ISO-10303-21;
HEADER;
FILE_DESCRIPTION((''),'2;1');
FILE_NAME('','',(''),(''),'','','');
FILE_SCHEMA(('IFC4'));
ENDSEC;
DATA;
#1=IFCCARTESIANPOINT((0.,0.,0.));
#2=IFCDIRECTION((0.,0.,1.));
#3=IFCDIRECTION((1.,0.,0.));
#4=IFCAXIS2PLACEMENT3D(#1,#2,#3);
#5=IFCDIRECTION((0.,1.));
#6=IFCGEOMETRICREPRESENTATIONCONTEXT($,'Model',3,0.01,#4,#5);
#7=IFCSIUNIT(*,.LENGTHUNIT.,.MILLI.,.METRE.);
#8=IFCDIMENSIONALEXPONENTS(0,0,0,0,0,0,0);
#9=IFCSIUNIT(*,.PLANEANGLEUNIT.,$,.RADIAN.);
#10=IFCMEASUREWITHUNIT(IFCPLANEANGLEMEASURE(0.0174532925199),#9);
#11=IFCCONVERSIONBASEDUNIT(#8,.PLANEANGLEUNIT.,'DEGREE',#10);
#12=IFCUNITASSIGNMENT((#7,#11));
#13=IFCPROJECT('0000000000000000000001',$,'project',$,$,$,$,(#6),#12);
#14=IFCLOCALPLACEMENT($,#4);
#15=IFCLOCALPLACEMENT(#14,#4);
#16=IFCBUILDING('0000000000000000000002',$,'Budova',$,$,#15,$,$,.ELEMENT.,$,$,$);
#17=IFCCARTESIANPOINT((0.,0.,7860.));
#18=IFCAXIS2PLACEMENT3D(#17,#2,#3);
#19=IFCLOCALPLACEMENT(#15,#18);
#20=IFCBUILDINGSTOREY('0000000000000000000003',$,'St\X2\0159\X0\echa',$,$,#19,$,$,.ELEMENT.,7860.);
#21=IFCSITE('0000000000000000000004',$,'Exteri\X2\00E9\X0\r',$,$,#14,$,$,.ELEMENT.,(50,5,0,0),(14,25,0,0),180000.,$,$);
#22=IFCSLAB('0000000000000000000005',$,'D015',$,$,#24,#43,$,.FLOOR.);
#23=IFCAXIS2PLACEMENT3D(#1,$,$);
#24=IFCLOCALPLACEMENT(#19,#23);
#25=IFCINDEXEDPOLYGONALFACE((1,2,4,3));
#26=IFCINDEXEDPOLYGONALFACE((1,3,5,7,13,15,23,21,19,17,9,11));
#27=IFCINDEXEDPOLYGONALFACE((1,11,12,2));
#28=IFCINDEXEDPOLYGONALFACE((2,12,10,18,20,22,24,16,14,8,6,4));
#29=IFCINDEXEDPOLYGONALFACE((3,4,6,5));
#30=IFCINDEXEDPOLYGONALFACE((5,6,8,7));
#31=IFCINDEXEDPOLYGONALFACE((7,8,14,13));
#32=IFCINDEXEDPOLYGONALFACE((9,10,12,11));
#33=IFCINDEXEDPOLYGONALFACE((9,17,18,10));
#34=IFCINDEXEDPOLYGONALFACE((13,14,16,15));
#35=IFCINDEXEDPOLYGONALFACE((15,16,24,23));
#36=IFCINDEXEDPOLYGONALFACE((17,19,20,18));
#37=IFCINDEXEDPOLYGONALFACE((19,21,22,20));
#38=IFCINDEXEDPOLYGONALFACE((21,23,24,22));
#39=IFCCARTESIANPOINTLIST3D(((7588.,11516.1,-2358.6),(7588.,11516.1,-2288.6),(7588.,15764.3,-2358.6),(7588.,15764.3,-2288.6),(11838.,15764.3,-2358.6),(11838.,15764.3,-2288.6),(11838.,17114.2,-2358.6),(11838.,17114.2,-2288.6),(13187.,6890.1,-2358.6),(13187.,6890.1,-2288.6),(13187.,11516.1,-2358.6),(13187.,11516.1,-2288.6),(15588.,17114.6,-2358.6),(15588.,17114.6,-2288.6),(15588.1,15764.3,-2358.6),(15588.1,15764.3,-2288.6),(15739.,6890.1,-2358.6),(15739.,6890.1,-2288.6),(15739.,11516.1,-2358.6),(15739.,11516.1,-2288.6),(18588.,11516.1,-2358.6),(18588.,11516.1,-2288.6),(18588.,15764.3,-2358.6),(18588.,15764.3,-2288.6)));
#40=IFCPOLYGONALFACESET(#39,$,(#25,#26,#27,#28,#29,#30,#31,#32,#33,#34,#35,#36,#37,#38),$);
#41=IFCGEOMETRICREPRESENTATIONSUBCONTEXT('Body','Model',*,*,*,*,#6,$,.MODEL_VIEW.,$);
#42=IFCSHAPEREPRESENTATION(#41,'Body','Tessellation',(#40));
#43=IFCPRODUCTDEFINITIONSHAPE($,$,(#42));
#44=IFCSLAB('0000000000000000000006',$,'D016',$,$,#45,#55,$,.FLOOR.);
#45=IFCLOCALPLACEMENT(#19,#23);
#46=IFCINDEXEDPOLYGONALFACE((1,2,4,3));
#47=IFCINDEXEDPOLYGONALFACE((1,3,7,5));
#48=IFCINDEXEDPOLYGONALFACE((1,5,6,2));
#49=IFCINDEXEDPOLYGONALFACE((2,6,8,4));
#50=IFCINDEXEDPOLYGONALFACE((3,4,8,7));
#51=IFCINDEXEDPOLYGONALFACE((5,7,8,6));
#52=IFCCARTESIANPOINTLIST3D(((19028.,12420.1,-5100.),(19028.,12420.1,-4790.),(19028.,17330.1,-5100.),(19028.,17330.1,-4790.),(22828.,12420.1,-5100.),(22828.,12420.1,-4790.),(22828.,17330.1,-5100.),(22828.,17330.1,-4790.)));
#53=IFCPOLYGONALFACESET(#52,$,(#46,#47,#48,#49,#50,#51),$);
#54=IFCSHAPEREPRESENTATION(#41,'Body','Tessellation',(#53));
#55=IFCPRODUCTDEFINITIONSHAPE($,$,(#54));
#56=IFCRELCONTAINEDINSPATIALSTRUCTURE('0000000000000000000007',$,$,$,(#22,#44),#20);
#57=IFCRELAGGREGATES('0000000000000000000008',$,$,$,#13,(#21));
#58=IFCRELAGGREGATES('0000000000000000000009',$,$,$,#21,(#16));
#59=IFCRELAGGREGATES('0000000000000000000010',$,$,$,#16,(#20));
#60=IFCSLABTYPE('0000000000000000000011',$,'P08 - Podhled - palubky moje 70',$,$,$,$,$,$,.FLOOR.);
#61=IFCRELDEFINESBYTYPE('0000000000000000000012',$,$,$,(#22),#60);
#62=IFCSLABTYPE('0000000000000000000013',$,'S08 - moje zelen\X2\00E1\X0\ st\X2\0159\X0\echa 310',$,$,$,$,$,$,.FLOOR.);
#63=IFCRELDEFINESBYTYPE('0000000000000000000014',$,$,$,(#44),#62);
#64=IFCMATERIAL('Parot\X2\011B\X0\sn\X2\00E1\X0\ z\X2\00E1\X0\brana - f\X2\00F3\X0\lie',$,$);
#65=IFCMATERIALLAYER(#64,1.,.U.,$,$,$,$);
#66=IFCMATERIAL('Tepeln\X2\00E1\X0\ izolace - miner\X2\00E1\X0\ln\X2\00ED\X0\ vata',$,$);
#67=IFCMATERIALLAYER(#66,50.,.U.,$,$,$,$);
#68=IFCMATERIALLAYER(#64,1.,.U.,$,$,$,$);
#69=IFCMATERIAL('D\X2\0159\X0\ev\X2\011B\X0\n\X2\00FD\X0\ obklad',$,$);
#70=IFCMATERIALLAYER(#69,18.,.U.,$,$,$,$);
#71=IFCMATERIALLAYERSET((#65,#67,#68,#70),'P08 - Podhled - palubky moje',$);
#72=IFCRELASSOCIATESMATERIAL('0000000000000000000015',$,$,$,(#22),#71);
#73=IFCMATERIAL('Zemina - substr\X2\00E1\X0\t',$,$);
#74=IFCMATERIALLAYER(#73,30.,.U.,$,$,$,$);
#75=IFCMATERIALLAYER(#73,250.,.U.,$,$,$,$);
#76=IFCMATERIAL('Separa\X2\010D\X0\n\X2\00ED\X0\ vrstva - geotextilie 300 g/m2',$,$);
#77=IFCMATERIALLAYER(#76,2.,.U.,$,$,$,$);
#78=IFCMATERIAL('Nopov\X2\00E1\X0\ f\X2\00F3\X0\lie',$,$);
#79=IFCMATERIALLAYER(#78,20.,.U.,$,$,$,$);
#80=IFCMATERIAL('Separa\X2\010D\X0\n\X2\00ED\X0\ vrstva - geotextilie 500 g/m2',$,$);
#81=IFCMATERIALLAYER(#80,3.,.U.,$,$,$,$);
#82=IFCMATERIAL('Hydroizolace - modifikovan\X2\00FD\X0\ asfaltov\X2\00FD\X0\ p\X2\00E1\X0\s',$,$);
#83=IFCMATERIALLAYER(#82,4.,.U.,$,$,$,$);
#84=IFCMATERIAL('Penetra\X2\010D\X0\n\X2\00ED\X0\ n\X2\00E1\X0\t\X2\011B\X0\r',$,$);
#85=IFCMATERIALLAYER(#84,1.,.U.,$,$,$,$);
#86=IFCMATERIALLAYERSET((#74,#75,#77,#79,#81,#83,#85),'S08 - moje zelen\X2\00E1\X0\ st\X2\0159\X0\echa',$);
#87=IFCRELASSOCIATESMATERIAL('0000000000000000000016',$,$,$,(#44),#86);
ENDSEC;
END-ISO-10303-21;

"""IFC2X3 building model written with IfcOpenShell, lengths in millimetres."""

from ifc_helpers import new_model, entity, si_unit, converted_unit, direction, frame, origin_with_axes, place, context, subcontext, project, spatial, polyline, outline, extrude, material, layer, layer_set, layer_usage, type_object, element, save


model = new_model("IFC2X3")

# Units and contexts
model_context = context("Model", 3, precision=0.01, world=origin_with_axes(), true_north=direction((0.0, 1.0)))
body_context = subcontext(model_context, "Body", "Model", "MODEL_VIEW")
ifc_project = project(units=[si_unit("LENGTHUNIT", "METRE", prefix="MILLI"), converted_unit("PLANEANGLEUNIT", "DEGREE", entity("IfcPlaneAngleMeasure", 0.0174532925199), si_unit("PLANEANGLEUNIT", "RADIAN"), dimensions=[0, 0, 0, 0, 0, 0, 0])], contexts=[model_context])

# Site, building, storey
site_placement = place(None, origin_with_axes())
site = spatial("IfcSite", under=ifc_project, at=site_placement, Name="Exteriér", CompositionType="ELEMENT", RefLatitude=(50, 5, 0, 0), RefLongitude=(14, 25, 0, 0), RefElevation=180000.0)
building_placement = place(site_placement, origin_with_axes())
building = spatial("IfcBuilding", under=site, at=building_placement, Name="Budova", CompositionType="ELEMENT")
storey_placement = place(building_placement, frame((0.0, 0.0, 7860.0), z_axis=(0.0, 0.0, 1.0), x_axis=(1.0, 0.0, 0.0)))
storey = spatial("IfcBuildingStorey", under=building, at=storey_placement, Name="Střecha", CompositionType="ELEMENT", Elevation=7860.0)

# Slabs
ifc_material_1 = material(Name="Parotěsná zábrana - fólie")
ifc_layer_1 = layer(ifc_material_1, 1.0, ventilated="UNKNOWN")
ifc_material_2 = material(Name="Tepelná izolace - minerální vata")
ifc_layer_2 = layer(ifc_material_2, 50.0, ventilated="UNKNOWN")
ifc_layer_3 = layer(ifc_material_1, 1.0, ventilated="UNKNOWN")
ifc_material_3 = material(Name="Dřevěný obklad")
ifc_layer_4 = layer(ifc_material_3, 18.0, ventilated="UNKNOWN")
ifc_layer_set_1 = layer_set([ifc_layer_1, ifc_layer_2, ifc_layer_3, ifc_layer_4], Name="P08 - Podhled - palubky moje")
ifc_layer_usage_1 = layer_usage(ifc_layer_set_1, "AXIS3", "NEGATIVE", 70.0)
slab_type_1 = type_object("IfcSlabType", Name="P08 - Podhled - palubky moje 70", PredefinedType="FLOOR")
slab_1_placement = place(storey_placement, frame((7588.0, 11516.1, -2288.6), z_axis=(0.0, 0.0, 1.0), x_axis=(1.0, 0.0, 0.0)))
element("IfcSlab", 1, at=slab_1_placement, inside=storey, type_object=slab_type_1, material=ifc_layer_usage_1, Name="D015", PredefinedType="FLOOR", context=body_context, shape_type="SweptSolid", body=[
    extrude(outline(polyline([(0.0, 0.0), (5599.0, 0.0), (5599.0, -4626.0), (8151.0, -4626.0), (8151.0, 0.0), (11000.0, 0.0), (11000.0, 4248.2), (8000.1, 4248.2), (8000.0, 5598.5), (4250.0, 5598.0), (4250.0, 4248.2), (0.0, 4248.2), (0.0, 0.0)])), frame((0.0, 0.0, -70.0), z_axis=(0.0, 0.0, 1.0), x_axis=(1.0, 0.0, 0.0)), (0.0, 0.0, 1.0), 70.0),
])
ifc_material_4 = material(Name="Zemina - substrát")
ifc_layer_5 = layer(ifc_material_4, 30.0, ventilated="UNKNOWN")
ifc_layer_6 = layer(ifc_material_4, 250.0, ventilated="UNKNOWN")
ifc_material_5 = material(Name="Separační vrstva - geotextilie 300 g/m2")
ifc_layer_7 = layer(ifc_material_5, 2.0, ventilated="UNKNOWN")
ifc_material_6 = material(Name="Nopová fólie")
ifc_layer_8 = layer(ifc_material_6, 20.0, ventilated="UNKNOWN")
ifc_material_7 = material(Name="Separační vrstva - geotextilie 500 g/m2")
ifc_layer_9 = layer(ifc_material_7, 3.0, ventilated="UNKNOWN")
ifc_material_8 = material(Name="Hydroizolace - modifikovaný asfaltový pás")
ifc_layer_10 = layer(ifc_material_8, 4.0, ventilated="UNKNOWN")
ifc_material_9 = material(Name="Penetrační nátěr")
ifc_layer_11 = layer(ifc_material_9, 1.0, ventilated="UNKNOWN")
ifc_layer_set_2 = layer_set([ifc_layer_5, ifc_layer_6, ifc_layer_7, ifc_layer_8, ifc_layer_9, ifc_layer_10, ifc_layer_11], Name="S08 - moje zelená střecha")
ifc_layer_usage_2 = layer_usage(ifc_layer_set_2, "AXIS3", "NEGATIVE", 310.0)
slab_type_2 = type_object("IfcSlabType", Name="S08 - moje zelená střecha 310", PredefinedType="FLOOR")
slab_2_placement = place(storey_placement, frame((19028.0, 12420.1, -5100.0), z_axis=(0.0, 0.0, 1.0), x_axis=(1.0, 0.0, 0.0)))
element("IfcSlab", 2, at=slab_2_placement, inside=storey, type_object=slab_type_2, material=ifc_layer_usage_2, Name="D016", PredefinedType="FLOOR", context=body_context, shape_type="SweptSolid", body=[
    extrude(outline(polyline([(0.0, 0.0), (3800.0, 0.0), (3800.0, 4910.0), (0.0, 4910.0), (0.0, 0.0)])), origin_with_axes(), (0.0, 0.0, 1.0), 310.0),
])

save(model, "model.ifc")
